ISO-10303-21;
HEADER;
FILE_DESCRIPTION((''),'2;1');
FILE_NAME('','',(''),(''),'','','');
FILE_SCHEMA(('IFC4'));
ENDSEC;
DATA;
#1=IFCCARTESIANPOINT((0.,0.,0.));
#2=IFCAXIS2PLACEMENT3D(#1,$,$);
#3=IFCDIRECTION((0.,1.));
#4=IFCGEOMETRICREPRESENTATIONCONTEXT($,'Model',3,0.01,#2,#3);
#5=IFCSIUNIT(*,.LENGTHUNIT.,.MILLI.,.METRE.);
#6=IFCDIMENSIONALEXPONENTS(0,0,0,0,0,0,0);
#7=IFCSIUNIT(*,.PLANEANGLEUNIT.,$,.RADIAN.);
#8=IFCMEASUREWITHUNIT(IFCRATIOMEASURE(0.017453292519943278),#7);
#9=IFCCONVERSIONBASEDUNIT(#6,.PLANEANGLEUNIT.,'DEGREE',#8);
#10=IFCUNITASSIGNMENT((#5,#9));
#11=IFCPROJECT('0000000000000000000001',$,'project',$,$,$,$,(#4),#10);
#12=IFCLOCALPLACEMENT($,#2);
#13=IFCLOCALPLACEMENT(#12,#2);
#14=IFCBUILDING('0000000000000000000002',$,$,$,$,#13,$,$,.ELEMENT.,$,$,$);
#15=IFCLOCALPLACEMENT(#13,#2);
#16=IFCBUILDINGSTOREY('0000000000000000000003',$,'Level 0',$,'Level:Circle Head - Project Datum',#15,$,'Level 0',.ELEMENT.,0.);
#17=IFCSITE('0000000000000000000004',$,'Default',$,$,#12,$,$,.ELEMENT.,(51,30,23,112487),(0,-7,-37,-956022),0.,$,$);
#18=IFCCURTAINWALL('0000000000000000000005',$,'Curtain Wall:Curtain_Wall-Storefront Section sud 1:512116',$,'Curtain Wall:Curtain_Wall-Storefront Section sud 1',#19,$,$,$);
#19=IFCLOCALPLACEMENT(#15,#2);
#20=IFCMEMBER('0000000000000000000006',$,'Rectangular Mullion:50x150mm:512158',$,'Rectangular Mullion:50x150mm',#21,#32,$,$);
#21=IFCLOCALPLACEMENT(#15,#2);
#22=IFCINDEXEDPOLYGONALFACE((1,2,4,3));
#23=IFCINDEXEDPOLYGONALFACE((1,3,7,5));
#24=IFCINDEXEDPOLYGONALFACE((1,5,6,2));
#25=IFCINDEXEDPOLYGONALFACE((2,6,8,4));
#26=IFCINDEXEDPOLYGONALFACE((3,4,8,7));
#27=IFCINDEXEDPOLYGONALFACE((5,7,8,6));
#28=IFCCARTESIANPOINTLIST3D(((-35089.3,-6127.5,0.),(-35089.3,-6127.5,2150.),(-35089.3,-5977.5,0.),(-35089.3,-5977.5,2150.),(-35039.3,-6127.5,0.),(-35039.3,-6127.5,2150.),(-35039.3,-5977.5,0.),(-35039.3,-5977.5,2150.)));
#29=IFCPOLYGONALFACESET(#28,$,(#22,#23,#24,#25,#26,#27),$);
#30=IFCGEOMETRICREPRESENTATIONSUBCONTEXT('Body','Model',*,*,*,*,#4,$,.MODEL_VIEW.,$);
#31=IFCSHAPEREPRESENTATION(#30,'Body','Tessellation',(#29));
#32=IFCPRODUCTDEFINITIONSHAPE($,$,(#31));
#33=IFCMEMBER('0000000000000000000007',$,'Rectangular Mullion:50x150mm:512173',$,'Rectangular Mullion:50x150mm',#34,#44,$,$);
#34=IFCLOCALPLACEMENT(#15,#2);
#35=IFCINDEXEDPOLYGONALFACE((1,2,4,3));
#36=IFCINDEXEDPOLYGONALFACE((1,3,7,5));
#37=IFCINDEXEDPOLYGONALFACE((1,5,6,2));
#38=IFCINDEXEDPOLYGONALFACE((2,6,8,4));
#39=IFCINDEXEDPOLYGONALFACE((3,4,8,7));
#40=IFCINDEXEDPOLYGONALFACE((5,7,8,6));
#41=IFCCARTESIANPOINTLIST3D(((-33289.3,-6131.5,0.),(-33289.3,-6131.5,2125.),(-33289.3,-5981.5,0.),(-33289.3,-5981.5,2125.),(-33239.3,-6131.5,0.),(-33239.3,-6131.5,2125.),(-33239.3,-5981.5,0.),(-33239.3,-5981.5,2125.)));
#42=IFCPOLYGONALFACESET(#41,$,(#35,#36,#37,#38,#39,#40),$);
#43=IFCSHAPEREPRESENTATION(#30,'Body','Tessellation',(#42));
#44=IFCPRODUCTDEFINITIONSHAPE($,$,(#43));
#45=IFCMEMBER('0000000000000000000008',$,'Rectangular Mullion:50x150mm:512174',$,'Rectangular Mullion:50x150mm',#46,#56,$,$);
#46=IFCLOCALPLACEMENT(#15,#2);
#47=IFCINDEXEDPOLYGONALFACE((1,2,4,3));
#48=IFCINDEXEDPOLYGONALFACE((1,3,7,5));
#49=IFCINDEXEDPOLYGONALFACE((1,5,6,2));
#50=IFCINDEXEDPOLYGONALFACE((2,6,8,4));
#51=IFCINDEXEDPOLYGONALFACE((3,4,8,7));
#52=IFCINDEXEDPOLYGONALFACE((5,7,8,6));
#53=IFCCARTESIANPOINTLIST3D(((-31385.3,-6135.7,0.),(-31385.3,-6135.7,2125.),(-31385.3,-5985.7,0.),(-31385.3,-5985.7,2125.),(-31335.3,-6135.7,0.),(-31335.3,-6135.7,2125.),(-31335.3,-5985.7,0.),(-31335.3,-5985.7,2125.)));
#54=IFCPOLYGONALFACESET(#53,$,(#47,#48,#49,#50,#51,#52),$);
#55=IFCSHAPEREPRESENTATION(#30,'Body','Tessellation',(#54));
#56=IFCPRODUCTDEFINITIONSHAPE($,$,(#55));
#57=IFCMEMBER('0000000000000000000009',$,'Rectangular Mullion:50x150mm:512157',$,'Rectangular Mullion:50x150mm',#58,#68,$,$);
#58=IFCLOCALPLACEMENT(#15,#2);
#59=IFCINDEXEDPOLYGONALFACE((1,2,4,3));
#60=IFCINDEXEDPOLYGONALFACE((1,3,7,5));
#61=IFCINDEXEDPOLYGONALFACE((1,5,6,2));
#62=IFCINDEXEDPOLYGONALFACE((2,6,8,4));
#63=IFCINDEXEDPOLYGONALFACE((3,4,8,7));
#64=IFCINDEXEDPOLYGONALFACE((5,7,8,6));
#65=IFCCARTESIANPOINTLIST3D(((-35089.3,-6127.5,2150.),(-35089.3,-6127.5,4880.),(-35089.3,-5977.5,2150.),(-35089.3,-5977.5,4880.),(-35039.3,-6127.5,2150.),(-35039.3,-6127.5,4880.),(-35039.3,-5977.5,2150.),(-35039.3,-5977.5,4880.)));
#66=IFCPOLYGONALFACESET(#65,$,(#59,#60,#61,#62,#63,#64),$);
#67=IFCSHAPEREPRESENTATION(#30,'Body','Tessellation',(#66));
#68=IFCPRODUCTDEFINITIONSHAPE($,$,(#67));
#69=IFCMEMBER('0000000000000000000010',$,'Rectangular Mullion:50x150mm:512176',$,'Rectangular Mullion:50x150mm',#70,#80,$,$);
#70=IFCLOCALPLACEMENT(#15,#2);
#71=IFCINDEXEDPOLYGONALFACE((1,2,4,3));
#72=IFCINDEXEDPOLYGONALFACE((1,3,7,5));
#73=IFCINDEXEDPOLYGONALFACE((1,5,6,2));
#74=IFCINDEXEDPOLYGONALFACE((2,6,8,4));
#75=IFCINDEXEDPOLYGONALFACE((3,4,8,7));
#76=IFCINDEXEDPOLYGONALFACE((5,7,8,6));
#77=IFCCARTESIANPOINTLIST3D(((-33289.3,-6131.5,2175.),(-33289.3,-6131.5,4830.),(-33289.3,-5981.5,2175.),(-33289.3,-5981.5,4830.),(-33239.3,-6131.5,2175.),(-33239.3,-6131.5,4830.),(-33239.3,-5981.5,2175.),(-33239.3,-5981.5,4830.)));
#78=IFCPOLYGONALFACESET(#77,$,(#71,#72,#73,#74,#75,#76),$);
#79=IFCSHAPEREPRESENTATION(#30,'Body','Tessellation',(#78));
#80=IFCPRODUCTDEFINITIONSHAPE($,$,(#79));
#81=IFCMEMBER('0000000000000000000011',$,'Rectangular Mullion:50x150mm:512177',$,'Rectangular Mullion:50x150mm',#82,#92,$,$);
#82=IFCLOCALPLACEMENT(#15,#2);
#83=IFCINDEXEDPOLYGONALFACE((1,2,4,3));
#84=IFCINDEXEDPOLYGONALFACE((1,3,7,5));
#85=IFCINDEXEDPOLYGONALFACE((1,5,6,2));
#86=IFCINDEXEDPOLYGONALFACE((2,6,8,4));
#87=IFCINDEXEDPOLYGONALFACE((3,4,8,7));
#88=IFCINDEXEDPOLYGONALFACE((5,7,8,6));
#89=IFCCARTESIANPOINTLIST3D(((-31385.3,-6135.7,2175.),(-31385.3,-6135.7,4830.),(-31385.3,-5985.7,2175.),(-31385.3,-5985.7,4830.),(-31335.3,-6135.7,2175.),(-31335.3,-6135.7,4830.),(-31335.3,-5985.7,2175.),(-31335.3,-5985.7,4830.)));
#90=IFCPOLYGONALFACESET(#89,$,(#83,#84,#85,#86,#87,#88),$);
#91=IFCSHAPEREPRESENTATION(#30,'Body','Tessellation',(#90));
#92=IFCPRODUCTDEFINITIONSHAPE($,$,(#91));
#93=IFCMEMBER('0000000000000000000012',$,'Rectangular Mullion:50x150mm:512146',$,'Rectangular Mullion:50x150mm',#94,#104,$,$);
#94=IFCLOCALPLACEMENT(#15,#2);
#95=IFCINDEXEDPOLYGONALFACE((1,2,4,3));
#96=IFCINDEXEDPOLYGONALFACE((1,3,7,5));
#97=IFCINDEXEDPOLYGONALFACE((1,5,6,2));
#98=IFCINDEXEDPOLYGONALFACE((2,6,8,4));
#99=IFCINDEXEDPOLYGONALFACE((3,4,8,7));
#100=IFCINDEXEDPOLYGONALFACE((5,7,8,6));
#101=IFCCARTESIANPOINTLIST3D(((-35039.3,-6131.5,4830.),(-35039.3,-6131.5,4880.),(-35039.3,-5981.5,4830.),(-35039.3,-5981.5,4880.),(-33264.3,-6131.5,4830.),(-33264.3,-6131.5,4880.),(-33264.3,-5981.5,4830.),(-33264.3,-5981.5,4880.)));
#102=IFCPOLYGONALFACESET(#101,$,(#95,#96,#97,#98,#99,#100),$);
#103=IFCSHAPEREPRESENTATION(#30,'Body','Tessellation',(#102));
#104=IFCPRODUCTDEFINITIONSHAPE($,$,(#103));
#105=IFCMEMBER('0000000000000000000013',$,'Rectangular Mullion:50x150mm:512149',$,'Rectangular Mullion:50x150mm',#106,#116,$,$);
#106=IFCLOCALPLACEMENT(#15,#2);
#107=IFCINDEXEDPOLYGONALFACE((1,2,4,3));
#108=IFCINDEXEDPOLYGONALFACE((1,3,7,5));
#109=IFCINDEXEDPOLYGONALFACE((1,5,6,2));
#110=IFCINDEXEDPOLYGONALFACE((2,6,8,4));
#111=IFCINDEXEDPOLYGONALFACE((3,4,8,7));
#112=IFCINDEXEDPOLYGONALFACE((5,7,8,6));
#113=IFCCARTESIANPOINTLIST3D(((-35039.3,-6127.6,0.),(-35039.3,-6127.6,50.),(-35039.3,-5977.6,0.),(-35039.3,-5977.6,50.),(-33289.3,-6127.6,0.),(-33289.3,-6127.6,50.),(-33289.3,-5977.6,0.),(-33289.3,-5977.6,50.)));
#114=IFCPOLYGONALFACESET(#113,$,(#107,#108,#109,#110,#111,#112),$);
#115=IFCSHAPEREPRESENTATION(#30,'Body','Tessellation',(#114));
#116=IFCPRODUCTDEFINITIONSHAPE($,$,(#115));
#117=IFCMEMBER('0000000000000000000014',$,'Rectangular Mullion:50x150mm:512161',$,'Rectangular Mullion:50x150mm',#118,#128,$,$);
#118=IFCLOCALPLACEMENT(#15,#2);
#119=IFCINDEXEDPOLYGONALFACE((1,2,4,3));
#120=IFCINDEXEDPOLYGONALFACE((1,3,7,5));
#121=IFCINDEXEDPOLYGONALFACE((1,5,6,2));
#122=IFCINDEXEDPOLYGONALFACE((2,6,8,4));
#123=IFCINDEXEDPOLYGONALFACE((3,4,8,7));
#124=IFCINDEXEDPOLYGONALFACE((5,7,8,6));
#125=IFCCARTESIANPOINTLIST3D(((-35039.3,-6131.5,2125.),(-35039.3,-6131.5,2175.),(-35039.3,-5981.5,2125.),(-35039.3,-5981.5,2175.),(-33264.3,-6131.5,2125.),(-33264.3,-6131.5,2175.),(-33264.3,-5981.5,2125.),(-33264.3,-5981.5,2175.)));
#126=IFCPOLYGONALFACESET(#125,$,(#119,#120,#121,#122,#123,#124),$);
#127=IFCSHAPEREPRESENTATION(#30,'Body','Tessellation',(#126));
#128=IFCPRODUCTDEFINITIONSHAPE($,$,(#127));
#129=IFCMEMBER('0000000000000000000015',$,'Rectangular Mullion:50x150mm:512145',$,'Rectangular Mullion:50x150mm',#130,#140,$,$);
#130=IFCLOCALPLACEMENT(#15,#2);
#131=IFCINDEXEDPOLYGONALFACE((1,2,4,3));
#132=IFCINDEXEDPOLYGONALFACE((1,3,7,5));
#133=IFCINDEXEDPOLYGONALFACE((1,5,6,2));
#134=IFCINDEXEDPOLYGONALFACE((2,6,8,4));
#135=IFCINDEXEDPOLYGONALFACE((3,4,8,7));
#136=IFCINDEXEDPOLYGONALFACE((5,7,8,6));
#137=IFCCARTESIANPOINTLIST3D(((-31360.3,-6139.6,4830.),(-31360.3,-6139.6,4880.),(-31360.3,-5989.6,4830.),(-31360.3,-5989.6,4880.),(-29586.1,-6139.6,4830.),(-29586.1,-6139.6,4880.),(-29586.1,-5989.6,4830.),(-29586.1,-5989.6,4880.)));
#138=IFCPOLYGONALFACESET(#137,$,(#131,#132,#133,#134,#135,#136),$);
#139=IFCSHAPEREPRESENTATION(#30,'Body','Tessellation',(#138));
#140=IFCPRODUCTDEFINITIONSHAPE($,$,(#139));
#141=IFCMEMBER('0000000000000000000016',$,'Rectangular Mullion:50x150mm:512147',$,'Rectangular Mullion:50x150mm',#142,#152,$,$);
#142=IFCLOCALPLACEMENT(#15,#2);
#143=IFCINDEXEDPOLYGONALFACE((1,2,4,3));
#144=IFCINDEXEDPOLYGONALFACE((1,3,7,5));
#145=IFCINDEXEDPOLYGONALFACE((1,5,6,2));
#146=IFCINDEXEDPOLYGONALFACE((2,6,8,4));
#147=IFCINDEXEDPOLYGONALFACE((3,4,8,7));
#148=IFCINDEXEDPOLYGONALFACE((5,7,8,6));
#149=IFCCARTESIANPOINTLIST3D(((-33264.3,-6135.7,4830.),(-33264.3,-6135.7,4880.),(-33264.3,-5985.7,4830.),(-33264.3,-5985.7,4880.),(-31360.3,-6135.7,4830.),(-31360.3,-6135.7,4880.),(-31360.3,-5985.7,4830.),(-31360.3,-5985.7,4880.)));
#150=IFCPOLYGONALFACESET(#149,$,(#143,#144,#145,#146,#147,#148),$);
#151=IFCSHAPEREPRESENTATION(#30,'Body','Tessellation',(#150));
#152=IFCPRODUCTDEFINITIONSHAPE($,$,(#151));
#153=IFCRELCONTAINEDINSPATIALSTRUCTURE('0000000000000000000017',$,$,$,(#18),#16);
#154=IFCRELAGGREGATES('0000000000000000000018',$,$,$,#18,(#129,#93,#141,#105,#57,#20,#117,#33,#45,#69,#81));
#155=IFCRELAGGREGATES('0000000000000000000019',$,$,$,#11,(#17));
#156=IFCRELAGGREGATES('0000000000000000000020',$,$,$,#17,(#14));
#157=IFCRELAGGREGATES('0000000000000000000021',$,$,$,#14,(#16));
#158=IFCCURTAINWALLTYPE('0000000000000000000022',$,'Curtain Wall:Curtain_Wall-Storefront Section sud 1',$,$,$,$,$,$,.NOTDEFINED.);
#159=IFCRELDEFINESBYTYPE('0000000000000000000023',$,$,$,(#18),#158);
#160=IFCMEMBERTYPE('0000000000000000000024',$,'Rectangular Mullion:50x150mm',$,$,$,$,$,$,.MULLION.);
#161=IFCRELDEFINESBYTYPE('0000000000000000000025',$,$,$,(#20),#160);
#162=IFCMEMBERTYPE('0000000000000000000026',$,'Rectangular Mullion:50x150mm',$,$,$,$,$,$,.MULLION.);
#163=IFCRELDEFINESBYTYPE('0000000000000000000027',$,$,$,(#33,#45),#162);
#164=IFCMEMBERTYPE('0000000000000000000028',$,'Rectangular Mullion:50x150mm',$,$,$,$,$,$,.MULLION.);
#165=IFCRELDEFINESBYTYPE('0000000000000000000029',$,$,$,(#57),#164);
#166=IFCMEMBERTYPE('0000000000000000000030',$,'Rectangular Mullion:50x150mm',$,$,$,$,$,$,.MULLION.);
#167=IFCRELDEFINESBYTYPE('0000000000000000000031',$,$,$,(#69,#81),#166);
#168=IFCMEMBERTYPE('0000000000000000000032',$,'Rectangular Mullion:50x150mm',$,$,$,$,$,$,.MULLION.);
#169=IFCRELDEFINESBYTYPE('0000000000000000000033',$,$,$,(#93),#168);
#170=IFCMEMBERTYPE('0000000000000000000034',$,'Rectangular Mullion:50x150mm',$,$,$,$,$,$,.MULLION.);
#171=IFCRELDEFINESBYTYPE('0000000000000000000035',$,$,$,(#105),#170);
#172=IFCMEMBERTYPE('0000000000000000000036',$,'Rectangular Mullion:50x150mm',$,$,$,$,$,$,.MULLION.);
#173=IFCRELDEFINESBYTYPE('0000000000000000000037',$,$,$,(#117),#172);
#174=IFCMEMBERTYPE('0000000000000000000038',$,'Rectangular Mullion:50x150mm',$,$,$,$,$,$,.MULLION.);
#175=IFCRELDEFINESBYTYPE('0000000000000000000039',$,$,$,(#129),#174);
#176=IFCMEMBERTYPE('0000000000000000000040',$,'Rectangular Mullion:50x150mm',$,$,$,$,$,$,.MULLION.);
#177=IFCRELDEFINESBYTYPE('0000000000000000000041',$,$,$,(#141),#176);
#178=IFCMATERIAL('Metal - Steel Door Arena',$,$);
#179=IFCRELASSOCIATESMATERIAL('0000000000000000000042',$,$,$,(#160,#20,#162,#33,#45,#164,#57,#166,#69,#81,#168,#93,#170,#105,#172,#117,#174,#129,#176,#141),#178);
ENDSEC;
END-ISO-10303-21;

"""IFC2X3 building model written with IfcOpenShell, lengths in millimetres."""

from ifc_helpers import new_model, entity, si_unit, converted_unit, direction, frame, origin, origin_2d_with_axis, place, context, subcontext, project, spatial, rectangle, extrude, source, transform, mapped, material, type_object, type_shapes, element, aggregate, save


model = new_model("IFC2X3")

# Units and contexts
model_context = context("Model", 3, precision=0.01, world=origin(), true_north=direction((0.0, 1.0)))
body_context = subcontext(model_context, "Body", "Model", "MODEL_VIEW")
ifc_project = project(units=[si_unit("LENGTHUNIT", "METRE", prefix="MILLI"), converted_unit("PLANEANGLEUNIT", "DEGREE", entity("IfcRatioMeasure", 0.017453292519943278), si_unit("PLANEANGLEUNIT", "RADIAN"), dimensions=[0, 0, 0, 0, 0, 0, 0])], contexts=[model_context])

# Site, building, storey
site_placement = place(None, origin())
site = spatial("IfcSite", under=ifc_project, at=site_placement, Name="Default", CompositionType="ELEMENT", RefLatitude=(51, 30, 23, 112487), RefLongitude=(0, -7, -37, -956022), RefElevation=0.0)
building_placement = place(site_placement, origin())
building = spatial("IfcBuilding", under=site, at=building_placement, CompositionType="ELEMENT")
storey_placement = place(building_placement, origin())
storey = spatial("IfcBuildingStorey", under=building, at=storey_placement, Name="Level 0", ObjectType="Level:Circle Head - Project Datum", LongName="Level 0", CompositionType="ELEMENT", Elevation=0.0)

# Curtain wall, members
curtain_wall_type = type_object("IfcCurtainWallType", Name="Curtain Wall:Curtain_Wall-Storefront Section sud 1", PredefinedType="NOTDEFINED")
curtain_wall_placement = place(storey_placement, origin())
curtain_wall = element("IfcCurtainWall", 1, at=curtain_wall_placement, inside=storey, type_object=curtain_wall_type, Name="Curtain Wall:Curtain_Wall-Storefront Section sud 1:512116", ObjectType="Curtain Wall:Curtain_Wall-Storefront Section sud 1")
ifc_material_1 = material(Name="Metal - Steel Door Arena")
member_type_1 = type_object("IfcMemberType", Name="Rectangular Mullion:50x150mm", PredefinedType="MULLION", material=ifc_material_1)
shared_shape_1 = source(origin(), body_context, "Body", "SweptSolid", [
    extrude(rectangle(XDim=150.0, YDim=50.0, at=origin_2d_with_axis()), frame((-25.0, 0.0, -2150.0), z_axis=(0.0, 0.0, 1.0), x_axis=(0.0, -1.0, 0.0)), (0.0, 0.0, 1.0), 2150.0),
])
type_shapes(member_type_1, [shared_shape_1])
member_1_placement = place(curtain_wall_placement, frame((-35089.3, -6052.5, 2150.0), z_axis=(0.0, 0.0, 1.0), x_axis=(-1.0, 0.0, 0.0)))
member_1 = element("IfcMember", 2, at=member_1_placement, type_object=member_type_1, material=ifc_material_1, Name="Rectangular Mullion:50x150mm:512158", ObjectType="Rectangular Mullion:50x150mm", context=body_context, shape_type="MappedRepresentation", body=[
    mapped(shared_shape_1, transform((0.0, 0.0, 0.0), scale=1.0)),
])
member_type_2 = type_object("IfcMemberType", Name="Rectangular Mullion:50x150mm", PredefinedType="MULLION", material=ifc_material_1)
shared_shape_2 = source(origin(), body_context, "Body", "SweptSolid", [
    extrude(rectangle(XDim=150.0, YDim=50.0, at=origin_2d_with_axis()), frame((0.0, 0.0, -2125.0), z_axis=(0.0, 0.0, 1.0), x_axis=(0.0, -1.0, 0.0)), (0.0, 0.0, 1.0), 2125.0),
])
type_shapes(member_type_2, [shared_shape_2])
member_2_placement = place(curtain_wall_placement, frame((-33264.3, -6056.5, 0.0), z_axis=(0.0, 0.0, -1.0), x_axis=(1.0, 0.0, 0.0)))
member_2 = element("IfcMember", 3, at=member_2_placement, type_object=member_type_2, material=ifc_material_1, Name="Rectangular Mullion:50x150mm:512173", ObjectType="Rectangular Mullion:50x150mm", context=body_context, shape_type="MappedRepresentation", body=[
    mapped(shared_shape_2, transform((0.0, 0.0, 0.0), scale=1.0)),
])
member_3_placement = place(curtain_wall_placement, frame((-31360.3, -6060.7, 0.0), z_axis=(0.0, 0.0, -1.0), x_axis=(1.0, 0.0, 0.0)))
member_3 = element("IfcMember", 4, at=member_3_placement, type_object=member_type_2, material=ifc_material_1, Name="Rectangular Mullion:50x150mm:512174", ObjectType="Rectangular Mullion:50x150mm", context=body_context, shape_type="MappedRepresentation", body=[
    mapped(shared_shape_2, transform((0.0, 0.0, 0.0), scale=1.0)),
])
member_type_3 = type_object("IfcMemberType", Name="Rectangular Mullion:50x150mm", PredefinedType="MULLION", material=ifc_material_1)
shared_shape_3 = source(origin(), body_context, "Body", "SweptSolid", [
    extrude(rectangle(XDim=150.0, YDim=50.0, at=origin_2d_with_axis()), frame((-25.0, 0.0, -2730.0), z_axis=(0.0, 0.0, 1.0), x_axis=(0.0, -1.0, 0.0)), (0.0, 0.0, 1.0), 2730.0),
])
type_shapes(member_type_3, [shared_shape_3])
member_4_placement = place(curtain_wall_placement, frame((-35089.3, -6052.5, 4880.0), z_axis=(0.0, 0.0, 1.0), x_axis=(-1.0, 0.0, 0.0)))
member_4 = element("IfcMember", 5, at=member_4_placement, type_object=member_type_3, material=ifc_material_1, Name="Rectangular Mullion:50x150mm:512157", ObjectType="Rectangular Mullion:50x150mm", context=body_context, shape_type="MappedRepresentation", body=[
    mapped(shared_shape_3, transform((0.0, 0.0, 0.0), scale=1.0)),
])
member_type_4 = type_object("IfcMemberType", Name="Rectangular Mullion:50x150mm", PredefinedType="MULLION", material=ifc_material_1)
shared_shape_4 = source(origin(), body_context, "Body", "SweptSolid", [
    extrude(rectangle(XDim=150.0, YDim=50.0, at=origin_2d_with_axis()), frame((0.0, 0.0, -2655.0), z_axis=(0.0, 0.0, 1.0), x_axis=(0.0, -1.0, 0.0)), (0.0, 0.0, 1.0), 2655.0),
])
type_shapes(member_type_4, [shared_shape_4])
member_5_placement = place(curtain_wall_placement, frame((-33264.3, -6056.5, 2175.0), z_axis=(0.0, 0.0, -1.0), x_axis=(1.0, 0.0, 0.0)))
member_5 = element("IfcMember", 6, at=member_5_placement, type_object=member_type_4, material=ifc_material_1, Name="Rectangular Mullion:50x150mm:512176", ObjectType="Rectangular Mullion:50x150mm", context=body_context, shape_type="MappedRepresentation", body=[
    mapped(shared_shape_4, transform((0.0, 0.0, 0.0), scale=1.0)),
])
member_6_placement = place(curtain_wall_placement, frame((-31360.3, -6060.7, 2175.0), z_axis=(0.0, 0.0, -1.0), x_axis=(1.0, 0.0, 0.0)))
member_6 = element("IfcMember", 7, at=member_6_placement, type_object=member_type_4, material=ifc_material_1, Name="Rectangular Mullion:50x150mm:512177", ObjectType="Rectangular Mullion:50x150mm", context=body_context, shape_type="MappedRepresentation", body=[
    mapped(shared_shape_4, transform((0.0, 0.0, 0.0), scale=1.0)),
])
member_type_5 = type_object("IfcMemberType", Name="Rectangular Mullion:50x150mm", PredefinedType="MULLION", material=ifc_material_1)
shared_shape_5 = source(origin(), body_context, "Body", "SweptSolid", [
    extrude(rectangle(XDim=150.0, YDim=50.0, at=origin_2d_with_axis()), frame((-25.0, 0.0, -1775.0), z_axis=(0.0, 0.0, 1.0), x_axis=(0.0, -1.0, 0.0)), (0.0, 0.0, 1.0), 1775.0),
])
type_shapes(member_type_5, [shared_shape_5])
member_7_placement = place(curtain_wall_placement, frame((-33264.3, -6056.5, 4880.0), z_axis=(1.0, 0.0, 0.0), x_axis=(0.0, 0.0, 1.0)))
member_7 = element("IfcMember", 8, at=member_7_placement, type_object=member_type_5, material=ifc_material_1, Name="Rectangular Mullion:50x150mm:512146", ObjectType="Rectangular Mullion:50x150mm", context=body_context, shape_type="MappedRepresentation", body=[
    mapped(shared_shape_5, transform((0.0, 0.0, 0.0), scale=1.0)),
])
member_type_6 = type_object("IfcMemberType", Name="Rectangular Mullion:50x150mm", PredefinedType="MULLION", material=ifc_material_1)
shared_shape_6 = source(origin(), body_context, "Body", "SweptSolid", [
    extrude(rectangle(XDim=150.0, YDim=50.0, at=origin_2d_with_axis()), frame((-25.0, 0.0, -1750.0), z_axis=(0.0, 0.0, 1.0), x_axis=(0.0, -1.0, 0.0)), (0.0, 0.0, 1.0), 1750.0),
])
type_shapes(member_type_6, [shared_shape_6])
member_8_placement = place(curtain_wall_placement, frame((-35039.3, -6052.6, 0.0), z_axis=(-1.0, 0.0, 0.0), x_axis=(0.0, 0.0, -1.0)))
member_8 = element("IfcMember", 9, at=member_8_placement, type_object=member_type_6, material=ifc_material_1, Name="Rectangular Mullion:50x150mm:512149", ObjectType="Rectangular Mullion:50x150mm", context=body_context, shape_type="MappedRepresentation", body=[
    mapped(shared_shape_6, transform((0.0, 0.0, 0.0), scale=1.0)),
])
member_type_7 = type_object("IfcMemberType", Name="Rectangular Mullion:50x150mm", PredefinedType="MULLION", material=ifc_material_1)
shared_shape_7 = source(origin(), body_context, "Body", "SweptSolid", [
    extrude(rectangle(XDim=150.0, YDim=50.0, at=origin_2d_with_axis()), frame((0.0, 0.0, -1775.0), z_axis=(0.0, 0.0, 1.0), x_axis=(0.0, -1.0, 0.0)), (0.0, 0.0, 1.0), 1775.0),
])
type_shapes(member_type_7, [shared_shape_7])
member_9_placement = place(curtain_wall_placement, frame((-33264.3, -6056.5, 2150.0), z_axis=(1.0, 0.0, 0.0), x_axis=(0.0, 0.0, 1.0)))
member_9 = element("IfcMember", 10, at=member_9_placement, type_object=member_type_7, material=ifc_material_1, Name="Rectangular Mullion:50x150mm:512161", ObjectType="Rectangular Mullion:50x150mm", context=body_context, shape_type="MappedRepresentation", body=[
    mapped(shared_shape_7, transform((0.0, 0.0, 0.0), scale=1.0)),
])
member_type_8 = type_object("IfcMemberType", Name="Rectangular Mullion:50x150mm", PredefinedType="MULLION", material=ifc_material_1)
shared_shape_8 = source(origin(), body_context, "Body", "SweptSolid", [
    extrude(rectangle(XDim=150.0, YDim=50.0, at=origin_2d_with_axis()), frame((-25.0, 0.0, -1774.2), z_axis=(0.0, 0.0, 1.0), x_axis=(0.0, -1.0, 0.0)), (0.0, 0.0, 1.0), 1774.2),
])
type_shapes(member_type_8, [shared_shape_8])
member_10_placement = place(curtain_wall_placement, frame((-29586.1, -6064.6, 4880.0), z_axis=(1.0, 0.0, 0.0), x_axis=(0.0, 0.0, 1.0)))
member_10 = element("IfcMember", 11, at=member_10_placement, type_object=member_type_8, material=ifc_material_1, Name="Rectangular Mullion:50x150mm:512145", ObjectType="Rectangular Mullion:50x150mm", context=body_context, shape_type="MappedRepresentation", body=[
    mapped(shared_shape_8, transform((0.0, 0.0, 0.0), scale=1.0)),
])
member_type_9 = type_object("IfcMemberType", Name="Rectangular Mullion:50x150mm", PredefinedType="MULLION", material=ifc_material_1)
shared_shape_9 = source(origin(), body_context, "Body", "SweptSolid", [
    extrude(rectangle(XDim=150.0, YDim=50.0, at=origin_2d_with_axis()), frame((-25.0, 0.0, -1904.0), z_axis=(0.0, 0.0, 1.0), x_axis=(0.0, -1.0, 0.0)), (0.0, 0.0, 1.0), 1904.0),
])
type_shapes(member_type_9, [shared_shape_9])
member_11_placement = place(curtain_wall_placement, frame((-31360.3, -6060.7, 4880.0), z_axis=(1.0, 0.0, 0.0), x_axis=(0.0, 0.0, 1.0)))
member_11 = element("IfcMember", 12, at=member_11_placement, type_object=member_type_9, material=ifc_material_1, Name="Rectangular Mullion:50x150mm:512147", ObjectType="Rectangular Mullion:50x150mm", context=body_context, shape_type="MappedRepresentation", body=[
    mapped(shared_shape_9, transform((0.0, 0.0, 0.0), scale=1.0)),
])
aggregate(curtain_wall, [member_10, member_7, member_11, member_8, member_4, member_1, member_9, member_2, member_3, member_5, member_6])

save(model, "model.ifc")
